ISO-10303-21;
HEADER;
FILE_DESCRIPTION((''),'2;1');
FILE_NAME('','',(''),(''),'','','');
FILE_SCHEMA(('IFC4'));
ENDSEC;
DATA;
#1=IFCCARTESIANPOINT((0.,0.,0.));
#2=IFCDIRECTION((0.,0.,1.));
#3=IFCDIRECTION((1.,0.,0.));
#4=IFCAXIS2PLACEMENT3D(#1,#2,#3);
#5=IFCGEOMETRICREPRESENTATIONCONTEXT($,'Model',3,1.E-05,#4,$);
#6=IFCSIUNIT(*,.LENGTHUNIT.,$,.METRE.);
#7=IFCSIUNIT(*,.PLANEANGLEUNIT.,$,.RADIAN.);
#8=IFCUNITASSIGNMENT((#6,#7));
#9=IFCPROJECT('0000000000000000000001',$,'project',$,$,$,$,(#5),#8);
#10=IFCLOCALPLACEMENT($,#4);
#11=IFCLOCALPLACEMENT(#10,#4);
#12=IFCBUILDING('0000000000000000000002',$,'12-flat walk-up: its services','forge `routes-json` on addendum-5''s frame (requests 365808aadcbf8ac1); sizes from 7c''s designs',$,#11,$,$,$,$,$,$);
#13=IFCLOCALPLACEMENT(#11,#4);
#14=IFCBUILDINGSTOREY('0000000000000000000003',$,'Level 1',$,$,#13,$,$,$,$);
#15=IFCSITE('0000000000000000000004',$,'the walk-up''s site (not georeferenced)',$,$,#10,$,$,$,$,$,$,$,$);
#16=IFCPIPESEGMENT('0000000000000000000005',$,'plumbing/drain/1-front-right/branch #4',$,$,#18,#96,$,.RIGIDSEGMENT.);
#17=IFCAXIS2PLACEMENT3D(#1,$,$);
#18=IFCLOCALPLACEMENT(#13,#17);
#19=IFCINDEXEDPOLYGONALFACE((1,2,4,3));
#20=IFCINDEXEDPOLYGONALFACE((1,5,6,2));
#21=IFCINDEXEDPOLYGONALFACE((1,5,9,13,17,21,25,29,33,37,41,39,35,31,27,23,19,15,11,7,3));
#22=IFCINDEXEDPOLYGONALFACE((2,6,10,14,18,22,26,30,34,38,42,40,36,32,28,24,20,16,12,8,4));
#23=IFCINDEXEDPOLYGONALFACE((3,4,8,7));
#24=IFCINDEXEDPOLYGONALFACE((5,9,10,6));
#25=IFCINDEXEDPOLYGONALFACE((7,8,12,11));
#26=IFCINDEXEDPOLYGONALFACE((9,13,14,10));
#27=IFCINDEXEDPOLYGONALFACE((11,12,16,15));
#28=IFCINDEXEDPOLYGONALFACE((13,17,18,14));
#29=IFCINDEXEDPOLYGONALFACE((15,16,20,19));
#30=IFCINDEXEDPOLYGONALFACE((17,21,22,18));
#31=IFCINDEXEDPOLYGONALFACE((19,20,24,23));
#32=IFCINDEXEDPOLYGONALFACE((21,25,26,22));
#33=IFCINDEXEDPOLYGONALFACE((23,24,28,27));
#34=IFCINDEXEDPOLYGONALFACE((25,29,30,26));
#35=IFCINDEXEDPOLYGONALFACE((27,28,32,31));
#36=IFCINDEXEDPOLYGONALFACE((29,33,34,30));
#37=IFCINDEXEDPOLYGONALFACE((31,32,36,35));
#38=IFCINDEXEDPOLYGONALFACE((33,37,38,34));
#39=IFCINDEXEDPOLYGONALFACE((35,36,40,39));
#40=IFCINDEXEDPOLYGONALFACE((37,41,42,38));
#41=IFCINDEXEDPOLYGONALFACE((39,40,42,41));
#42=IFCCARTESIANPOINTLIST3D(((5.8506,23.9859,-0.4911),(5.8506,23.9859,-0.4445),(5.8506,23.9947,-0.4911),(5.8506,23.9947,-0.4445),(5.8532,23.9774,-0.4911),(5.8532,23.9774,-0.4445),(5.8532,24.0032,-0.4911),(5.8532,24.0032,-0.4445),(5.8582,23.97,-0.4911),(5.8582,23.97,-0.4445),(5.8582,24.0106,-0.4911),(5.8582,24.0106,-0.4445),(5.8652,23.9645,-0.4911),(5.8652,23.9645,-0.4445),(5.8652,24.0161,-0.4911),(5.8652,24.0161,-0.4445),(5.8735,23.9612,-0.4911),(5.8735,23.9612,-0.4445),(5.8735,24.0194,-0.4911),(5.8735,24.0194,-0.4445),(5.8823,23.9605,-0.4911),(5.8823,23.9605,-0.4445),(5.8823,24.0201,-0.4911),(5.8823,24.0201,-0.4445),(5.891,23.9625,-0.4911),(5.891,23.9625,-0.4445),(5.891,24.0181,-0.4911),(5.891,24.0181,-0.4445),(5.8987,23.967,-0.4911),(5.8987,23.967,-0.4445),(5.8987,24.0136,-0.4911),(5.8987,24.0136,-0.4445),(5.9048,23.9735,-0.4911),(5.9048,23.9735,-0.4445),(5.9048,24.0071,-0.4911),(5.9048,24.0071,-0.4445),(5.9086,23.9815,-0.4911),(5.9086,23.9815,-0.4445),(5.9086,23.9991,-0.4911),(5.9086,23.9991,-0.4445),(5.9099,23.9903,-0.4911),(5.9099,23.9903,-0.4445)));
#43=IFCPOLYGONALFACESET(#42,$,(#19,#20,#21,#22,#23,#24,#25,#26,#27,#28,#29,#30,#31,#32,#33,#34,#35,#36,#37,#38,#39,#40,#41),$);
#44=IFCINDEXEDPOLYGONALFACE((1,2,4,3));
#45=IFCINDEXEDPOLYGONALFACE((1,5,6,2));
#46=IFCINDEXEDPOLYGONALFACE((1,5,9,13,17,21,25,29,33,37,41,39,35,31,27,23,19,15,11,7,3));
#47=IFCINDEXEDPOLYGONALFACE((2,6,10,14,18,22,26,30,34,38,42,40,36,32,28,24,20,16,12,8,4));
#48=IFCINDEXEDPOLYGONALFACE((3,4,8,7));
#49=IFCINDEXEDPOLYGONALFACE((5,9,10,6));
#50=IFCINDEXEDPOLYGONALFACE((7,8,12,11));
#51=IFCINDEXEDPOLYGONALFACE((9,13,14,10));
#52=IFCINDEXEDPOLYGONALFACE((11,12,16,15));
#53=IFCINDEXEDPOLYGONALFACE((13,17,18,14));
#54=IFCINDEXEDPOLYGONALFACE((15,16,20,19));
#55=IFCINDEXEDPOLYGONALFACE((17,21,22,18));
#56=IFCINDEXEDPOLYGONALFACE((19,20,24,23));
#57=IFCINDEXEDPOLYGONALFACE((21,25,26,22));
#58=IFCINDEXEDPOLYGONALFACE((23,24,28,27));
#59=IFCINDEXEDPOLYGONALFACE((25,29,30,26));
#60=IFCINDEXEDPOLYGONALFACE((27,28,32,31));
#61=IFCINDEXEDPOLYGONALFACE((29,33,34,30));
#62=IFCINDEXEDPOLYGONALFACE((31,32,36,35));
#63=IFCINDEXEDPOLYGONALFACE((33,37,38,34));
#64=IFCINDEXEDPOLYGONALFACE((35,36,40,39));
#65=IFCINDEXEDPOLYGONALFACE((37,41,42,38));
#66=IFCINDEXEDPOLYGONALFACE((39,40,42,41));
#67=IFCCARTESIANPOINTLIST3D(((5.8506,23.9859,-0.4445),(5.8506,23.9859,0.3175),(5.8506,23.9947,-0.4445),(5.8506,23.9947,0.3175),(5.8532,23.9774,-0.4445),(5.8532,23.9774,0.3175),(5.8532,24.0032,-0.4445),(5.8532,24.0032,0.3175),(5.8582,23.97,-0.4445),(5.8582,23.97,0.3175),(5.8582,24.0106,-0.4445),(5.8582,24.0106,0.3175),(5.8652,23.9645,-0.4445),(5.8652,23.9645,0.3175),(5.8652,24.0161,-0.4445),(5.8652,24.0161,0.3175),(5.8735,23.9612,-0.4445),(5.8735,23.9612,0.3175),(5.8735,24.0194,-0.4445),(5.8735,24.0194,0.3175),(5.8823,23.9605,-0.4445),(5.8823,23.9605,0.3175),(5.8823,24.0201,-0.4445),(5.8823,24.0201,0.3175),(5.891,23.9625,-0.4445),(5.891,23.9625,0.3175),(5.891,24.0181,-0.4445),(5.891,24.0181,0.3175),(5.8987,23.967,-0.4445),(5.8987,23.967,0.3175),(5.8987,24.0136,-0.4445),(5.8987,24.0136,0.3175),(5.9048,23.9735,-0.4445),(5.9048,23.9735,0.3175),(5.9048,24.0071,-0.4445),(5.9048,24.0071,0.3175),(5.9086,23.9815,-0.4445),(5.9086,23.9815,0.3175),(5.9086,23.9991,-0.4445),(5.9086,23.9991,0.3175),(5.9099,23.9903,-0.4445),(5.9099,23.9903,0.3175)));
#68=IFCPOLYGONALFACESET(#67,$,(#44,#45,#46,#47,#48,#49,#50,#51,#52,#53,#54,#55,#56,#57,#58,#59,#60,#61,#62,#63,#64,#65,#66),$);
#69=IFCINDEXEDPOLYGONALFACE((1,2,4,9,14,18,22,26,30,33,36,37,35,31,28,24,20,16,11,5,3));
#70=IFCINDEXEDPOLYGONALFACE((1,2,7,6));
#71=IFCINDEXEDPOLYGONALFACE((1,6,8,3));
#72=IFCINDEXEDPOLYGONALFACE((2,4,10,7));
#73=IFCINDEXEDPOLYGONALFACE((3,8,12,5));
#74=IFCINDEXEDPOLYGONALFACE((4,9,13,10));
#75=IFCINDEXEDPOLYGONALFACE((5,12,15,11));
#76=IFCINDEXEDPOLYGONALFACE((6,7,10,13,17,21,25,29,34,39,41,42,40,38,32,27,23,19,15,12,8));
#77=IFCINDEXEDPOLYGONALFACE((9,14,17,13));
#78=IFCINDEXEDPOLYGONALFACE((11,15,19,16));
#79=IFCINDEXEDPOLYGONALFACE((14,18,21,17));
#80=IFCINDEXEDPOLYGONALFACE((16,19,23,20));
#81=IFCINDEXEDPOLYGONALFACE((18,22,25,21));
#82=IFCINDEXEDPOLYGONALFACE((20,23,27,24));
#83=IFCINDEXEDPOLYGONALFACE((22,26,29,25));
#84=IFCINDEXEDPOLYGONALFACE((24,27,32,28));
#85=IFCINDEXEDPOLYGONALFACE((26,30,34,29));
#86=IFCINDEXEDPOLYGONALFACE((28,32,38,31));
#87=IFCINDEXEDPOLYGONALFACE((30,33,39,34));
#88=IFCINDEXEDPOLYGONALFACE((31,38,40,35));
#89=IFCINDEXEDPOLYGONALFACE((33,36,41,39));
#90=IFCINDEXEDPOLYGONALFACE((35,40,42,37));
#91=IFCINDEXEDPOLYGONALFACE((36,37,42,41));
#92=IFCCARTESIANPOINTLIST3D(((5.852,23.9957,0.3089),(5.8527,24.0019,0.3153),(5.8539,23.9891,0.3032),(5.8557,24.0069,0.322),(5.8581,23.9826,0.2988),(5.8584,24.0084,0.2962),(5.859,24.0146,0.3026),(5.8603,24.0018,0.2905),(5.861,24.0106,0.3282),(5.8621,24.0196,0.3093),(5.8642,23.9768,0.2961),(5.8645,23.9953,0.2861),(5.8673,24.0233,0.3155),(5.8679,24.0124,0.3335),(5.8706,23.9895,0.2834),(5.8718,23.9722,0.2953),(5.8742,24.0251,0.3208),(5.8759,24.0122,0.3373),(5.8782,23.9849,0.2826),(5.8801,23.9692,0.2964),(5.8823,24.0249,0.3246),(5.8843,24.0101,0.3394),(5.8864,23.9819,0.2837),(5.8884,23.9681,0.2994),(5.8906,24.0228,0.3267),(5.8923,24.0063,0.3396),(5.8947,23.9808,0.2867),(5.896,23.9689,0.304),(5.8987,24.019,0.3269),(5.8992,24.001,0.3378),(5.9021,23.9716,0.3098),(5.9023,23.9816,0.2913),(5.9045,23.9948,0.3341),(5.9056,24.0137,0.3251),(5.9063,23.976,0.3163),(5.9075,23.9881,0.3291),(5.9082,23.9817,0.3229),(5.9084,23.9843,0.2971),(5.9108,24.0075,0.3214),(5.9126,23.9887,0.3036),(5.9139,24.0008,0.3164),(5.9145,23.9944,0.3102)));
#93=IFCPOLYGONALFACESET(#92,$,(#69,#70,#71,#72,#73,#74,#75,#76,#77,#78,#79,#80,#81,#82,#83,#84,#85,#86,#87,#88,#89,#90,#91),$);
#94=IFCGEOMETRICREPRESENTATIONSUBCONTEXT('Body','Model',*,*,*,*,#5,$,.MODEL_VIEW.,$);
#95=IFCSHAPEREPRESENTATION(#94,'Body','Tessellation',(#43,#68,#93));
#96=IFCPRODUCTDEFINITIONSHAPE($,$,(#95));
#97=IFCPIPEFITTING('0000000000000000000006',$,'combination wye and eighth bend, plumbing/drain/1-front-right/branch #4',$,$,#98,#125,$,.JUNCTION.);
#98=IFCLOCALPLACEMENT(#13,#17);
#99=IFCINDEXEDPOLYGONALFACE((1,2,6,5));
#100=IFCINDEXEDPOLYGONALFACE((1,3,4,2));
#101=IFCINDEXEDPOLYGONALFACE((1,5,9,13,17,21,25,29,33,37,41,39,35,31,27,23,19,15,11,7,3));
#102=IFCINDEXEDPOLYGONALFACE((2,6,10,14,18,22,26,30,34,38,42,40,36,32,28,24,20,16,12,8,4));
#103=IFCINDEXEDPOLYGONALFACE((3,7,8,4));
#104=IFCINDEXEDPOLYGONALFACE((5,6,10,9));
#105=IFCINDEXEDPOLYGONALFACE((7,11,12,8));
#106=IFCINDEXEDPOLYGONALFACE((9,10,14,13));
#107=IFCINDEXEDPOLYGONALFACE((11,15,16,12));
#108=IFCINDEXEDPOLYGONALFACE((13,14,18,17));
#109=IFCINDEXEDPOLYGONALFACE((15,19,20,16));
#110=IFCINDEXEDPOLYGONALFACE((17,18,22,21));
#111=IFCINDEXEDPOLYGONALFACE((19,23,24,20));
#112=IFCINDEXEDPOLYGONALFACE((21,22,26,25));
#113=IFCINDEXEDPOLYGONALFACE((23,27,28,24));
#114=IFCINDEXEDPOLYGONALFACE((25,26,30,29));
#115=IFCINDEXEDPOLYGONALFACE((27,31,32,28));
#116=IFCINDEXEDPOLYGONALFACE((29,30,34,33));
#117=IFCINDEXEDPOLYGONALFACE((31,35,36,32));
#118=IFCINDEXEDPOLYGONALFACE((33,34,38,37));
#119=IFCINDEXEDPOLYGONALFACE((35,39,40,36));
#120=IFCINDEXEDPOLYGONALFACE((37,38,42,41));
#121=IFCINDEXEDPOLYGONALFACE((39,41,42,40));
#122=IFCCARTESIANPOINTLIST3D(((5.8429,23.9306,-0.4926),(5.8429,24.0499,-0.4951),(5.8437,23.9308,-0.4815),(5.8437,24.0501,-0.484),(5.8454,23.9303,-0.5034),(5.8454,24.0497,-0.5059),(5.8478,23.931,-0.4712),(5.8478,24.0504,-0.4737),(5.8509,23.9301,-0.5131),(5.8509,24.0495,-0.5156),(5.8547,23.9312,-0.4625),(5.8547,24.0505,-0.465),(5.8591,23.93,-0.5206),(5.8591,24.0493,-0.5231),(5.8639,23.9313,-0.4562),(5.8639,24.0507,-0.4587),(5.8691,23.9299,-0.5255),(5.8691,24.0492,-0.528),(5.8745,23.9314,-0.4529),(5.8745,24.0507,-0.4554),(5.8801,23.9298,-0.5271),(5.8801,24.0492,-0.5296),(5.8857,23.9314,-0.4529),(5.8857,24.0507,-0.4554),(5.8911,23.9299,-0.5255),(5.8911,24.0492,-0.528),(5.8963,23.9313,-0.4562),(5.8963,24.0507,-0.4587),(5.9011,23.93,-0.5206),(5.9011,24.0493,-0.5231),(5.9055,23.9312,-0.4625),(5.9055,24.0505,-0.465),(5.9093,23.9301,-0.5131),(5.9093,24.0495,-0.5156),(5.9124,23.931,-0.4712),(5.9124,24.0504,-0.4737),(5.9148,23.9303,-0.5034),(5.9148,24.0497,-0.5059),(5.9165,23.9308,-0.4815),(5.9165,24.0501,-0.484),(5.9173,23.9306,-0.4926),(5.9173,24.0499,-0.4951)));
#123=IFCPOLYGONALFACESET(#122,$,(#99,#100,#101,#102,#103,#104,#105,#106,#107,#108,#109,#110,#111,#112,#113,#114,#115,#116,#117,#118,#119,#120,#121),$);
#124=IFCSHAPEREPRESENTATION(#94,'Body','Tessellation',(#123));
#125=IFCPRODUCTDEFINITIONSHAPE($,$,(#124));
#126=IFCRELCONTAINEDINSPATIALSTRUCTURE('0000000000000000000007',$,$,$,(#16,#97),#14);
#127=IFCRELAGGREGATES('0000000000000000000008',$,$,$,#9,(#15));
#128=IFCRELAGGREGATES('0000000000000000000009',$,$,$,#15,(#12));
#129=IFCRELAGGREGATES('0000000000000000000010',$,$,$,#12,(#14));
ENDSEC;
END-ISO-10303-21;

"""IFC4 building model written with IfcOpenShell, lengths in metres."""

from ifc_helpers import new_model, entity, si_unit, frame, origin_with_axes, place, context, subcontext, project, spatial, element, save


model = new_model("IFC4")

# Units and contexts
model_context = context("Model", 3, precision=1e-05, world=origin_with_axes())
body_context = subcontext(model_context, "Body", "Model", "MODEL_VIEW")
ifc_project = project(units=[si_unit("LENGTHUNIT", "METRE"), si_unit("PLANEANGLEUNIT", "RADIAN")], contexts=[model_context])

# Site, building, storey
site_placement = place(None, origin_with_axes())
site = spatial("IfcSite", under=ifc_project, at=site_placement, Name="the walk-up's site (not georeferenced)")
building_placement = place(site_placement, origin_with_axes())
building = spatial("IfcBuilding", under=site, at=building_placement, Name="12-flat walk-up: its services", Description="forge `routes-json` on addendum-5's frame (requests 365808aadcbf8ac1); sizes from 7c's designs")
storey_placement = place(building_placement, origin_with_axes())
storey = spatial("IfcBuildingStorey", under=building, at=storey_placement, Name="Level 1")

# Pipe segment
pipe_segment_1_placement = place(storey_placement, frame((5.8801, 23.9903, -0.4911), z_axis=(0.0, 0.0, 1.0), x_axis=(1.0, 0.0, 0.0)))
element("IfcPipeSegment", 1, at=pipe_segment_1_placement, inside=storey, Name="plumbing/drain/1-front-right/branch #4", PredefinedType="RIGIDSEGMENT", context=body_context, shape_type="AdvancedSweptSolid", body=[
    entity("IfcSweptDiskSolid", entity("IfcPolyline", [entity("IfcCartesianPoint", [0.0, 0.0, 0.0]), entity("IfcCartesianPoint", [0.0, 0.0, 0.0466])]), 0.0298),
    entity("IfcSweptDiskSolid", entity("IfcPolyline", [entity("IfcCartesianPoint", [0.0, 0.0, 0.0466]), entity("IfcCartesianPoint", [0.0, 0.0, 0.8086])]), 0.0298),
    entity("IfcSweptDiskSolid", entity("IfcPolyline", [entity("IfcCartesianPoint", [0.0, 0.0, 0.8086]), entity("IfcCartesianPoint", [0.0064, 0.0127, 0.7959])]), 0.0298),
])

# Pipe fitting
pipe_fitting_1_placement = place(storey_placement, frame((5.8801, 24.05, -0.4923), z_axis=(0.0, 0.0, 1.0), x_axis=(1.0, 0.0, 0.0)))
element("IfcPipeFitting", 2, at=pipe_fitting_1_placement, inside=storey, Name="combination wye and eighth bend, plumbing/drain/1-front-right/branch #4", PredefinedType="JUNCTION", context=body_context, shape_type="AdvancedSweptSolid", body=[
    entity("IfcSweptDiskSolid", entity("IfcPolyline", [entity("IfcCartesianPoint", [0.0, 0.0, 0.0]), entity("IfcCartesianPoint", [0.0, -0.1194, 0.0025])]), 0.0373),
])

save(model, "model.ifc")
